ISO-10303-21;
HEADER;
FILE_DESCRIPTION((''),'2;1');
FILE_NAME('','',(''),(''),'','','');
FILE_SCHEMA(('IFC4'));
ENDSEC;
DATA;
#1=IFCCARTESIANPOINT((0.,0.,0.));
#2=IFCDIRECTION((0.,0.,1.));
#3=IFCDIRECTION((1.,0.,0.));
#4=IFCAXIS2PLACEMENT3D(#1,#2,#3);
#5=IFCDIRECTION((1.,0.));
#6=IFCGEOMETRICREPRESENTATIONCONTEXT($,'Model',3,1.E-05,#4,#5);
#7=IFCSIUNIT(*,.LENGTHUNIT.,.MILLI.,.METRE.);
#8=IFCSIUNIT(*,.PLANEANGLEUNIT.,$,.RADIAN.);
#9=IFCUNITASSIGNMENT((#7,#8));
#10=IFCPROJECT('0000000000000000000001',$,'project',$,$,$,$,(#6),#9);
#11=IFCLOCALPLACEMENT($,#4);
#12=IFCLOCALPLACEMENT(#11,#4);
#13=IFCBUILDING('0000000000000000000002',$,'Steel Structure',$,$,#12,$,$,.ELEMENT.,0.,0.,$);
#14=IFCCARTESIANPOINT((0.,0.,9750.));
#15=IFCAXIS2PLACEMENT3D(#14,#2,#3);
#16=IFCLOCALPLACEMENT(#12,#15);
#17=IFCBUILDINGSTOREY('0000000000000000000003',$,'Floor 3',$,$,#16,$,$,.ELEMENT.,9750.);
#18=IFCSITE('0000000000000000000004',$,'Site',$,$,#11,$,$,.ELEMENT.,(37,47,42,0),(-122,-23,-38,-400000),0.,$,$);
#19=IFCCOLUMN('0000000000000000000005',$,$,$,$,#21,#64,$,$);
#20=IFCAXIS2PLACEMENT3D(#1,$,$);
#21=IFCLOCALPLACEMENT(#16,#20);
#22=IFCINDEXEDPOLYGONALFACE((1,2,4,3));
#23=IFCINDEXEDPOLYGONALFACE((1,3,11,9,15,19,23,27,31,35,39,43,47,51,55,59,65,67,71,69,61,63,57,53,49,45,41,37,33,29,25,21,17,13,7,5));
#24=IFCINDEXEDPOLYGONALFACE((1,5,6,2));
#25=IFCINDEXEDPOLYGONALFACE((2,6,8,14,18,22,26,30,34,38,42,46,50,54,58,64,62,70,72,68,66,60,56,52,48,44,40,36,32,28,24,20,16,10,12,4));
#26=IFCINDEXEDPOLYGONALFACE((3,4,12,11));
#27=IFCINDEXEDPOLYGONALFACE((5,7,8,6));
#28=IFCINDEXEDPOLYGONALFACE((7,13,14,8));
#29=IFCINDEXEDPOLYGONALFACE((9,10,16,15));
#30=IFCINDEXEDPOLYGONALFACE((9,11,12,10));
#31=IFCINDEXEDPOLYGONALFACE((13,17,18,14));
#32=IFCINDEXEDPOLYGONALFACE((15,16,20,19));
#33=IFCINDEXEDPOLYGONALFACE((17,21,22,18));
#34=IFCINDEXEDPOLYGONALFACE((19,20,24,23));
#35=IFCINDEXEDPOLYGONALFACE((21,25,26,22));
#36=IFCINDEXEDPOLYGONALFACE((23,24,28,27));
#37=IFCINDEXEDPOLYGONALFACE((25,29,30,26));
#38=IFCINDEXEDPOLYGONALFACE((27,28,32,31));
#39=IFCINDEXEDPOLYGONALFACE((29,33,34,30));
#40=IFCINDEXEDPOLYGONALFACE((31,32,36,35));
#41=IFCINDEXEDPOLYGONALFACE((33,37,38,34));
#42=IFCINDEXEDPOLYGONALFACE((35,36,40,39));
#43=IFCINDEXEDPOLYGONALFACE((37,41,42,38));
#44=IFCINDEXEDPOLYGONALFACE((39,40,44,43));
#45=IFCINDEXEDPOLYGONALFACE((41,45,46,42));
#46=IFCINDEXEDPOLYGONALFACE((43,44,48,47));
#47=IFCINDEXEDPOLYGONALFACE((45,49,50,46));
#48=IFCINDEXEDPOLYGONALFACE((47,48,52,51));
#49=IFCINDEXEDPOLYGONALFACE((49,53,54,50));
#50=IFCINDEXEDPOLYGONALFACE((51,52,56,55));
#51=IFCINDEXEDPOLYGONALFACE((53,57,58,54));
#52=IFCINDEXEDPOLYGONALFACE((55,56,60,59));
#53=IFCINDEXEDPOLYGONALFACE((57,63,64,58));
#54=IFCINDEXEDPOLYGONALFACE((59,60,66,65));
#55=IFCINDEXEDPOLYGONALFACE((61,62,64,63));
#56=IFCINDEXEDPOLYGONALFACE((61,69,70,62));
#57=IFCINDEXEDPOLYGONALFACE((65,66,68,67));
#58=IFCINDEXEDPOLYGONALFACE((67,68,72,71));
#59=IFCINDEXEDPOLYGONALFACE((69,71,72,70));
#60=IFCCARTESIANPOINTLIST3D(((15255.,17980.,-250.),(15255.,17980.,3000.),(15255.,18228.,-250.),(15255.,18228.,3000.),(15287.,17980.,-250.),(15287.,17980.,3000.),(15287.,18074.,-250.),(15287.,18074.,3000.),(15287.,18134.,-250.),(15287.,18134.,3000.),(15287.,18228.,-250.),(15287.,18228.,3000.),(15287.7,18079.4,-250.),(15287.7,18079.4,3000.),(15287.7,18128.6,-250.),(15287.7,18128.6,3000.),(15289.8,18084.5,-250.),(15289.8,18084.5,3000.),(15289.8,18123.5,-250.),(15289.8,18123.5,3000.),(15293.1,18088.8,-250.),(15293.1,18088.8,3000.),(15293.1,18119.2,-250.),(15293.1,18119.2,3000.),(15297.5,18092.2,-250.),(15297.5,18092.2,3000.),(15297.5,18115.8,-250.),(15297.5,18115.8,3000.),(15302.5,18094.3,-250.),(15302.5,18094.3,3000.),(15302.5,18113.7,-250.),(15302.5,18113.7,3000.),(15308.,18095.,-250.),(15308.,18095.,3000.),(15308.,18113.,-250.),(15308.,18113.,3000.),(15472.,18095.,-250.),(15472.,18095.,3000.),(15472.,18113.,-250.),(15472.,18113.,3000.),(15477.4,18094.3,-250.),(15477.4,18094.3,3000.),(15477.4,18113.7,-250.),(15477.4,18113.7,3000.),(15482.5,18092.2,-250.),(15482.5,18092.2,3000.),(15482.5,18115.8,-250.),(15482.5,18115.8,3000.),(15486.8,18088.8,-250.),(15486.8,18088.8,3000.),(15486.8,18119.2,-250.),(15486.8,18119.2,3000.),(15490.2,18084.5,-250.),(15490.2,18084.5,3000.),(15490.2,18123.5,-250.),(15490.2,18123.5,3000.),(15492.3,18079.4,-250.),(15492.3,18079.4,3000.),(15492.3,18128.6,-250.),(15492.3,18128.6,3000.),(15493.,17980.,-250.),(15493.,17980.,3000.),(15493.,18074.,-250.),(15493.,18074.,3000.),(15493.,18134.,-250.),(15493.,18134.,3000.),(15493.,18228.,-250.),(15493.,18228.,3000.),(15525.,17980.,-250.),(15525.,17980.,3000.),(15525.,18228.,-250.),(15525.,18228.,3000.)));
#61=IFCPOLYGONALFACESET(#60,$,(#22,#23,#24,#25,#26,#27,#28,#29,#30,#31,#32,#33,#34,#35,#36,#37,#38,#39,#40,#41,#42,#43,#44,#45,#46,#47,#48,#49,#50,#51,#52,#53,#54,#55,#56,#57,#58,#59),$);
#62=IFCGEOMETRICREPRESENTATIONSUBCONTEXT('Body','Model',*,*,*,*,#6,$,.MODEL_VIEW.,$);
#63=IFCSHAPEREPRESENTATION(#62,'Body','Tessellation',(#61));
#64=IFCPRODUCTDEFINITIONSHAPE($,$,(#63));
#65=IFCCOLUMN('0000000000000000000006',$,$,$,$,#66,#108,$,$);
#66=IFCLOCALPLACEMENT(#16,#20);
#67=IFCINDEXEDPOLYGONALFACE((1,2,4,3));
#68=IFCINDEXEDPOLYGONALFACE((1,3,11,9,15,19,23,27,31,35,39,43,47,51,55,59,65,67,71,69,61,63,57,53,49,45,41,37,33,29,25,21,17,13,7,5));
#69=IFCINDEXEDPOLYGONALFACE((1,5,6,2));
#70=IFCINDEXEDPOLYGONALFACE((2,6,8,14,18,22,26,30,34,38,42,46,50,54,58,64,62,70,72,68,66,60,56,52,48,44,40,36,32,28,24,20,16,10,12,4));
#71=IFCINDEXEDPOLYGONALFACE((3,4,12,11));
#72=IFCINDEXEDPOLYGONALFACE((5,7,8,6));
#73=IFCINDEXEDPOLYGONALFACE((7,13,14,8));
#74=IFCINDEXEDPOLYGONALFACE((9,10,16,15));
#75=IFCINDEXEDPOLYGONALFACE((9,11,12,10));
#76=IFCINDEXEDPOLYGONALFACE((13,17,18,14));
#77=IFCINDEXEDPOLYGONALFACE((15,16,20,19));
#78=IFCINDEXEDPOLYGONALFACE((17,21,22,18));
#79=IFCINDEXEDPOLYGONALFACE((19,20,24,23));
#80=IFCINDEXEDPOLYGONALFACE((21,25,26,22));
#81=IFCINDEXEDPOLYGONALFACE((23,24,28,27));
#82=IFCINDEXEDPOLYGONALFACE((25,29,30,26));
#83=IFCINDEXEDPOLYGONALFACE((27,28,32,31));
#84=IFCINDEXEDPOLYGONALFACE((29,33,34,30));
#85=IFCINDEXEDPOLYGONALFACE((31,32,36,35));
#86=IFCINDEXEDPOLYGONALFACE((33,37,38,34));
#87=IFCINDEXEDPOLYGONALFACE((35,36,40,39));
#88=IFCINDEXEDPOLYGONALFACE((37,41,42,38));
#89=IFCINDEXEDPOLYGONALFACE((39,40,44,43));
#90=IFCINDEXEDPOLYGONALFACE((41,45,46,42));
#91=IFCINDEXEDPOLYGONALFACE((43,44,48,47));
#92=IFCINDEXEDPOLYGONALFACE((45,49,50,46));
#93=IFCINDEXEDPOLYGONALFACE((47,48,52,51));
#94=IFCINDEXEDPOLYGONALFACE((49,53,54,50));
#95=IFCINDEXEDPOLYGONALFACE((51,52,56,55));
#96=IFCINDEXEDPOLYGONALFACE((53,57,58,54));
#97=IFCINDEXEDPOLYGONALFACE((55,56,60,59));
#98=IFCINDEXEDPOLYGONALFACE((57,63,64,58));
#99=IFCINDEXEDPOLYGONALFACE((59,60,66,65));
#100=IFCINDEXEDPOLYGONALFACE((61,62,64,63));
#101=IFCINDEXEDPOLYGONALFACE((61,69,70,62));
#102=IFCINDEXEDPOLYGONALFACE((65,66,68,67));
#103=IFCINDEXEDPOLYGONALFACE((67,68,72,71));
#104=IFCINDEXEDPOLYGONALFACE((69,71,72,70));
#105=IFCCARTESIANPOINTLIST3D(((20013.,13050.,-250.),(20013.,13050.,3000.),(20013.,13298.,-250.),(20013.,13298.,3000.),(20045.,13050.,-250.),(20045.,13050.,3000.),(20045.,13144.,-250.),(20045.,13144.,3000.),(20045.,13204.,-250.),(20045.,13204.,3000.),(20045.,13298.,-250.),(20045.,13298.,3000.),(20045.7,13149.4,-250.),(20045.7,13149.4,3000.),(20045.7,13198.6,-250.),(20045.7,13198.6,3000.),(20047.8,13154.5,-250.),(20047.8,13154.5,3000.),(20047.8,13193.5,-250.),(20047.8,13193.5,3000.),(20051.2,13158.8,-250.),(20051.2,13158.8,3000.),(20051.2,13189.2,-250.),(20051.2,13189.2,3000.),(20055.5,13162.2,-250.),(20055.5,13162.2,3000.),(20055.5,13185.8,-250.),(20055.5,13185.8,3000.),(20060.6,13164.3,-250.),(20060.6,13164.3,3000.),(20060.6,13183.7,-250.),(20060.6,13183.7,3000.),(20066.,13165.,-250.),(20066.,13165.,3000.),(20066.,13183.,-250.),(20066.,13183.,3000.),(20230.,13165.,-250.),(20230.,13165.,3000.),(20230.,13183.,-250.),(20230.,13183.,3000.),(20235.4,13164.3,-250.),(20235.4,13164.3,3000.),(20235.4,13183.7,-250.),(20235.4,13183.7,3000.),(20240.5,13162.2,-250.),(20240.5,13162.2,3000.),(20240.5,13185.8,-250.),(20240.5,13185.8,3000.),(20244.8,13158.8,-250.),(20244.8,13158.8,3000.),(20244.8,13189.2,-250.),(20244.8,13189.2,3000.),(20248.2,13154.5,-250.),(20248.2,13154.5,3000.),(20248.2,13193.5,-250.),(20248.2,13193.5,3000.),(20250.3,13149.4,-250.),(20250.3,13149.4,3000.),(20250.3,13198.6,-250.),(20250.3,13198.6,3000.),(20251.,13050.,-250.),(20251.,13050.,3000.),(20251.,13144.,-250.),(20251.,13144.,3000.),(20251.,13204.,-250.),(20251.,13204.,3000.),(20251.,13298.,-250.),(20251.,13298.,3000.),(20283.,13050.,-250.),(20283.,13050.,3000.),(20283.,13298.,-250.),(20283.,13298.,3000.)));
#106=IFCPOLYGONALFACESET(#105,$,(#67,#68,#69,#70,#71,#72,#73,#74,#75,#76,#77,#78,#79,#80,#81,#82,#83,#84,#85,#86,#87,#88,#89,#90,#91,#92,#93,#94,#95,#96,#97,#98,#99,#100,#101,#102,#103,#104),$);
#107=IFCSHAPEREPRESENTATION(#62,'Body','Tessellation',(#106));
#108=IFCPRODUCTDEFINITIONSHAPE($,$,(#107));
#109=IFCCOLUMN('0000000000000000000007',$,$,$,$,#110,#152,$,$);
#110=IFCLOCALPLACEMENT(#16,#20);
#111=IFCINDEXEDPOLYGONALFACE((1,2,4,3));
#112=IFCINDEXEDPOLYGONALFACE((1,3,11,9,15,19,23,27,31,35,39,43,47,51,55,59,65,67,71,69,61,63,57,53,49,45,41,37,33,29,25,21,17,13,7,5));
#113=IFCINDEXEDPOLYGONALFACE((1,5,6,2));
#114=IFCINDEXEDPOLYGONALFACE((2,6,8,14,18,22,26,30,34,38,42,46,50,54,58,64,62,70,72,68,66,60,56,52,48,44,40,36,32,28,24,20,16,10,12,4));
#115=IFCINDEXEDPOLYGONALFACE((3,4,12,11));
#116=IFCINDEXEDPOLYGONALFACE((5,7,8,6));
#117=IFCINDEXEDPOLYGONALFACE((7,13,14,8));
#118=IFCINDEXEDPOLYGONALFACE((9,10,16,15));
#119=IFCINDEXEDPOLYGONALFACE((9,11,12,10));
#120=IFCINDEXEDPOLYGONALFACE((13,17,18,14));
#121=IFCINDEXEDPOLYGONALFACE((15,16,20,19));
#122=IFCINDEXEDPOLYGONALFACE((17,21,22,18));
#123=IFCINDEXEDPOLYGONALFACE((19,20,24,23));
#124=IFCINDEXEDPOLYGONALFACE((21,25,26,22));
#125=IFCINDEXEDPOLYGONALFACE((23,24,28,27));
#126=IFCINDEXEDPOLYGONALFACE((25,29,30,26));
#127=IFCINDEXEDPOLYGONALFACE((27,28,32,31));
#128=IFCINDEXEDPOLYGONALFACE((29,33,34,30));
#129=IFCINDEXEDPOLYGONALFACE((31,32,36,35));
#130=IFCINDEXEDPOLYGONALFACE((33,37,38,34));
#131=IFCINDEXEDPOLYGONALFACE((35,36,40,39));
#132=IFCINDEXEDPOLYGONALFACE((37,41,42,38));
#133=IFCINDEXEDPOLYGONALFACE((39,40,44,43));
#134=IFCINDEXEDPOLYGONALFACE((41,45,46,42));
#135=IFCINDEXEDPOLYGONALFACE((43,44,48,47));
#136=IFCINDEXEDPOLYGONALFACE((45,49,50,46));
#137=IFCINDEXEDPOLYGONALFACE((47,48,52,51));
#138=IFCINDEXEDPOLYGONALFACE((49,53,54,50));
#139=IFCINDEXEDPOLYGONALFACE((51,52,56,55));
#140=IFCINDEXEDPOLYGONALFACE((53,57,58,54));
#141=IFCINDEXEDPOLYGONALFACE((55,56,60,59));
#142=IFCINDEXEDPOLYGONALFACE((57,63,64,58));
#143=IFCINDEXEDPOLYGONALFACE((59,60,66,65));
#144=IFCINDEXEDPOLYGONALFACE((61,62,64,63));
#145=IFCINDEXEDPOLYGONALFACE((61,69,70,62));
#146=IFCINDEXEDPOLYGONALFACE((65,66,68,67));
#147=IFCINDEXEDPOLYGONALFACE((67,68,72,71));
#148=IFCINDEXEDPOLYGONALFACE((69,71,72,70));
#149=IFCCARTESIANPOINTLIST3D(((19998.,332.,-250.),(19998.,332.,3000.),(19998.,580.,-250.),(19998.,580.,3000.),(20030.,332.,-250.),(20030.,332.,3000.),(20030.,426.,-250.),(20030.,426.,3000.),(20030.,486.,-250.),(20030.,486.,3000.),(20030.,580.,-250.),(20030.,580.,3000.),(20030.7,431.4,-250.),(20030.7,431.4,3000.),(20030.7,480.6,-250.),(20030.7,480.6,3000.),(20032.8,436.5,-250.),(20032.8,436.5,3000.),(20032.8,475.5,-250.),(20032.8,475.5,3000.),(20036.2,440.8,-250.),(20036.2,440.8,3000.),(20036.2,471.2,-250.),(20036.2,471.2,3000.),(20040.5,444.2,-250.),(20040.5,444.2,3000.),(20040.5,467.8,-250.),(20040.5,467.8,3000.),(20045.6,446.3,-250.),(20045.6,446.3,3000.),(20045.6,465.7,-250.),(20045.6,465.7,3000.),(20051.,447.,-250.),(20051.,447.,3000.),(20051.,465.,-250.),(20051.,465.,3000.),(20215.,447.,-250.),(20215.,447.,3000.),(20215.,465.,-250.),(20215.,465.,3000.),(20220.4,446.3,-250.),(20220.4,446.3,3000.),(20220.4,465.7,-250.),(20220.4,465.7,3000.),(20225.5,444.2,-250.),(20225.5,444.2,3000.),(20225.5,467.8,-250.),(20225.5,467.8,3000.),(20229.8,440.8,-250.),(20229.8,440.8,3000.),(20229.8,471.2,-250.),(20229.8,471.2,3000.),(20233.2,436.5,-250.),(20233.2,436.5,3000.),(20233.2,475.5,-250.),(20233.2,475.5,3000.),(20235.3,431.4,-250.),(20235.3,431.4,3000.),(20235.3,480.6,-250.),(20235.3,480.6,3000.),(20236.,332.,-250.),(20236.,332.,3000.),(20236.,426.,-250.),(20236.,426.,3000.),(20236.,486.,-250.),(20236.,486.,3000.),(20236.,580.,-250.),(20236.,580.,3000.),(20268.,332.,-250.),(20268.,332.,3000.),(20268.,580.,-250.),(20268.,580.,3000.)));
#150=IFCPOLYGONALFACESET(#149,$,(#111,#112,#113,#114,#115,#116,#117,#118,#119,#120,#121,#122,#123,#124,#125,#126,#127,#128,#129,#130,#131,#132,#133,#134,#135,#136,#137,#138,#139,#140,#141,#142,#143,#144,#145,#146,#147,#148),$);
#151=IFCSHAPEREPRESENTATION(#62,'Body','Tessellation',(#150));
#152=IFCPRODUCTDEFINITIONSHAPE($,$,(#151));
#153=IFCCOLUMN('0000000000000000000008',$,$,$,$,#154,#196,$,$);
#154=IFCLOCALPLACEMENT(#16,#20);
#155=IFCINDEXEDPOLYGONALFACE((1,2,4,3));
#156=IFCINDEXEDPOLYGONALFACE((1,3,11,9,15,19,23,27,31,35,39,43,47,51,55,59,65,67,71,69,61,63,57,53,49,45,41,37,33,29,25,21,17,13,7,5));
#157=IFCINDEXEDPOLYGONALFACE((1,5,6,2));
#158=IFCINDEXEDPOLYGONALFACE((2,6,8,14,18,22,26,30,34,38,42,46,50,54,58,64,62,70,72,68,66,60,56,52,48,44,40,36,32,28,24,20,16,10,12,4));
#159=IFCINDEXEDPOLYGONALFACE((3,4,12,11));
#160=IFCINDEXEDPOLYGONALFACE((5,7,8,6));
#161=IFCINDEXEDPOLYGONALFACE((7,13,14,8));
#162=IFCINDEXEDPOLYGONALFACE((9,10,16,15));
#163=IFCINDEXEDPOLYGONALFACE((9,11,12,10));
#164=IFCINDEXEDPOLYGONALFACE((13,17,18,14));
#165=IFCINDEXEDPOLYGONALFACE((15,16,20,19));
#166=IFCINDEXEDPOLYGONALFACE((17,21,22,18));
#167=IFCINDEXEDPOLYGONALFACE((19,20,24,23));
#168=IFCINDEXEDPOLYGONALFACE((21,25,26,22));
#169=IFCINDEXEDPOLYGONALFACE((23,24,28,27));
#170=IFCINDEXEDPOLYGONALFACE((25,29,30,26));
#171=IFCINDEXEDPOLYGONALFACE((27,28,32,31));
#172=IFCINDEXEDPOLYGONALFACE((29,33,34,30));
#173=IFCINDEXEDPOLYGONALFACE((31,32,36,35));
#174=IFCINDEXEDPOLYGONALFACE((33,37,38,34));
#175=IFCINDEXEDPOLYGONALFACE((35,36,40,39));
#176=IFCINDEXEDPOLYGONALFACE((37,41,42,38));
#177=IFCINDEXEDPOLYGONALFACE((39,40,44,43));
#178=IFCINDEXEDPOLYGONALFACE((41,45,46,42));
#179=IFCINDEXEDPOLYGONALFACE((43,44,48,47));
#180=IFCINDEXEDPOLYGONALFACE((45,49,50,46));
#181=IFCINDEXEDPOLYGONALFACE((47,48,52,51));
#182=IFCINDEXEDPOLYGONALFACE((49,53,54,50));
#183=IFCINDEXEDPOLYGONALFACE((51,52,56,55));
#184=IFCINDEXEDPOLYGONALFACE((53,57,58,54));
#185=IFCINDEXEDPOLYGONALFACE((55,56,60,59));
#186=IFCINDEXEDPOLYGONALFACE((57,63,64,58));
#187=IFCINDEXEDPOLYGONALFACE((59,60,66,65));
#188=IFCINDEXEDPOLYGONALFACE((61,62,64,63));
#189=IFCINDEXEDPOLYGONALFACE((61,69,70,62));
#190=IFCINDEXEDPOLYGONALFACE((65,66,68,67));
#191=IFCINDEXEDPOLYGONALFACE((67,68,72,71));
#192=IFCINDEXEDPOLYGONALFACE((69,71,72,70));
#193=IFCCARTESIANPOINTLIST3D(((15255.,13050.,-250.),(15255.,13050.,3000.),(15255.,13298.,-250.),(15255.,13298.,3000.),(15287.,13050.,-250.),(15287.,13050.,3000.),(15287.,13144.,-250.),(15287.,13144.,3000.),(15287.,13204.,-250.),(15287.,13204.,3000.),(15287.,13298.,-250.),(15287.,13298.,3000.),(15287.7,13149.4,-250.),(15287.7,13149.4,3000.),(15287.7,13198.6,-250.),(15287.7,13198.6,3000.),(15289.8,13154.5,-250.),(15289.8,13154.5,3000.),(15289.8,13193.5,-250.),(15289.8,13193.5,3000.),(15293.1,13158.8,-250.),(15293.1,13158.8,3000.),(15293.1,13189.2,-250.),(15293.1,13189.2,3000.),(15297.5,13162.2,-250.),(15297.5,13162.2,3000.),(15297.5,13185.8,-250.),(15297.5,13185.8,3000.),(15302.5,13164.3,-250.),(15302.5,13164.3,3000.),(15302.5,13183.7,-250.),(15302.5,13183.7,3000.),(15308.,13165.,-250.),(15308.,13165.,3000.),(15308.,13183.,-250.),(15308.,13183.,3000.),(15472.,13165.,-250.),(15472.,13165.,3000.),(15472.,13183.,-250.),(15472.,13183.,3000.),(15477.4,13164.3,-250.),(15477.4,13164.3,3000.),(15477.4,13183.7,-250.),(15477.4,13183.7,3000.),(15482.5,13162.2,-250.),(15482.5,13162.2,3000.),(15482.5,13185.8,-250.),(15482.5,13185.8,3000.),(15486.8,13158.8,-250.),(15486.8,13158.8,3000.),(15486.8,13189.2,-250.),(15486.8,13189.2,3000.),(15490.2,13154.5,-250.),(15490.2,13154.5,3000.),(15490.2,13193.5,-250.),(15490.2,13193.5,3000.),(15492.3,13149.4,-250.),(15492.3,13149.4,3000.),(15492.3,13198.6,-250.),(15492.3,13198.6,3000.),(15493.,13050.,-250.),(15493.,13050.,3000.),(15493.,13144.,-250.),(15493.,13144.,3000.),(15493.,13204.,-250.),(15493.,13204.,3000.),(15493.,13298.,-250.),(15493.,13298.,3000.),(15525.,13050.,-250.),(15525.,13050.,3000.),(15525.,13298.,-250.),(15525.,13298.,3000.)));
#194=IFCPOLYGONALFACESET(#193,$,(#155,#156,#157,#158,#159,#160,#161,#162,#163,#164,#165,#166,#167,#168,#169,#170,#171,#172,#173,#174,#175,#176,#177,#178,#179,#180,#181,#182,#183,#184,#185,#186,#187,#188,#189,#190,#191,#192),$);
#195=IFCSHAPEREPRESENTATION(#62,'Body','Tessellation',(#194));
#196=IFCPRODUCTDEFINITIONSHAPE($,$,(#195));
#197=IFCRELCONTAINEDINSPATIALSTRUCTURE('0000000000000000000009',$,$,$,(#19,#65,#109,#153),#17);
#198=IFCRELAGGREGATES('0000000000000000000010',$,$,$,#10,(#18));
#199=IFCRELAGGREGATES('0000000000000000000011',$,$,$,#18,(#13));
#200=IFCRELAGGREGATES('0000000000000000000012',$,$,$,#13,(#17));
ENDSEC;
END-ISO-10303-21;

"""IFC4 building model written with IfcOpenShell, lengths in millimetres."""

from ifc_helpers import new_model, si_unit, direction, frame, origin_with_axes, origin_2d_with_axis, place, context, subcontext, project, spatial, i_section, extrude, element, save


model = new_model("IFC4")

# Units and contexts
model_context = context("Model", 3, precision=1e-05, world=origin_with_axes(), true_north=direction((1.0, 0.0)))
body_context = subcontext(model_context, "Body", "Model", "MODEL_VIEW")
ifc_project = project(units=[si_unit("LENGTHUNIT", "METRE", prefix="MILLI"), si_unit("PLANEANGLEUNIT", "RADIAN")], contexts=[model_context])

# Site, building, storey
site_placement = place(None, origin_with_axes())
site = spatial("IfcSite", under=ifc_project, at=site_placement, Name="Site", CompositionType="ELEMENT", RefLatitude=(37, 47, 42, 0), RefLongitude=(-122, -23, -38, -400000), RefElevation=0.0)
building_placement = place(site_placement, origin_with_axes())
building = spatial("IfcBuilding", under=site, at=building_placement, Name="Steel Structure", CompositionType="ELEMENT", ElevationOfRefHeight=0.0, ElevationOfTerrain=0.0)
storey_placement = place(building_placement, frame((0.0, 0.0, 9750.0), z_axis=(0.0, 0.0, 1.0), x_axis=(1.0, 0.0, 0.0)))
storey = spatial("IfcBuildingStorey", under=building, at=storey_placement, Name="Floor 3", CompositionType="ELEMENT", Elevation=9750.0)

# Columns
for number, where, z_axis, x_axis in (
    (1, (15390.0, 18104.0, -250.0), (0.0, 0.0, 1.0), (0.0, -1.0, 0.0)),
    (2, (20148.0, 13174.0, -250.0), (0.0, 0.0, 1.0), (0.0, -1.0, 0.0)),
):
    element("IfcColumn", number, at=place(storey_placement, frame(where, z_axis=z_axis, x_axis=x_axis)), inside=storey, context=body_context, shape_type="SweptSolid", body=[
        extrude(i_section(OverallWidth=248.0, OverallDepth=270.0, WebThickness=18.0, FlangeThickness=32.0, FilletRadius=21.0, at=origin_2d_with_axis()), origin_with_axes(), (0.0, 0.0, 1.0), 3250.0),
    ])
column_1_placement = place(storey_placement, frame((20133.0, 456.0, -250.0), z_axis=(0.0, 0.0, 1.0), x_axis=(0.0, 1.0, 0.0)))
element("IfcColumn", 3, at=column_1_placement, inside=storey, context=body_context, shape_type="SweptSolid", body=[
    extrude(i_section(OverallWidth=248.0, OverallDepth=270.0, WebThickness=18.0, FlangeThickness=32.0, FilletRadius=21.0, at=origin_2d_with_axis()), origin_with_axes(), (0.0, 0.0, 1.0), 3250.0),
])
for number, where, z_axis, x_axis in (
    (4, (15390.0, 13174.0, -250.0), (0.0, 0.0, 1.0), (0.0, -1.0, 0.0)),
):
    element("IfcColumn", number, at=place(storey_placement, frame(where, z_axis=z_axis, x_axis=x_axis)), inside=storey, context=body_context, shape_type="SweptSolid", body=[
        extrude(i_section(OverallWidth=248.0, OverallDepth=270.0, WebThickness=18.0, FlangeThickness=32.0, FilletRadius=21.0, at=origin_2d_with_axis()), origin_with_axes(), (0.0, 0.0, 1.0), 3250.0),
    ])

save(model, "model.ifc")
